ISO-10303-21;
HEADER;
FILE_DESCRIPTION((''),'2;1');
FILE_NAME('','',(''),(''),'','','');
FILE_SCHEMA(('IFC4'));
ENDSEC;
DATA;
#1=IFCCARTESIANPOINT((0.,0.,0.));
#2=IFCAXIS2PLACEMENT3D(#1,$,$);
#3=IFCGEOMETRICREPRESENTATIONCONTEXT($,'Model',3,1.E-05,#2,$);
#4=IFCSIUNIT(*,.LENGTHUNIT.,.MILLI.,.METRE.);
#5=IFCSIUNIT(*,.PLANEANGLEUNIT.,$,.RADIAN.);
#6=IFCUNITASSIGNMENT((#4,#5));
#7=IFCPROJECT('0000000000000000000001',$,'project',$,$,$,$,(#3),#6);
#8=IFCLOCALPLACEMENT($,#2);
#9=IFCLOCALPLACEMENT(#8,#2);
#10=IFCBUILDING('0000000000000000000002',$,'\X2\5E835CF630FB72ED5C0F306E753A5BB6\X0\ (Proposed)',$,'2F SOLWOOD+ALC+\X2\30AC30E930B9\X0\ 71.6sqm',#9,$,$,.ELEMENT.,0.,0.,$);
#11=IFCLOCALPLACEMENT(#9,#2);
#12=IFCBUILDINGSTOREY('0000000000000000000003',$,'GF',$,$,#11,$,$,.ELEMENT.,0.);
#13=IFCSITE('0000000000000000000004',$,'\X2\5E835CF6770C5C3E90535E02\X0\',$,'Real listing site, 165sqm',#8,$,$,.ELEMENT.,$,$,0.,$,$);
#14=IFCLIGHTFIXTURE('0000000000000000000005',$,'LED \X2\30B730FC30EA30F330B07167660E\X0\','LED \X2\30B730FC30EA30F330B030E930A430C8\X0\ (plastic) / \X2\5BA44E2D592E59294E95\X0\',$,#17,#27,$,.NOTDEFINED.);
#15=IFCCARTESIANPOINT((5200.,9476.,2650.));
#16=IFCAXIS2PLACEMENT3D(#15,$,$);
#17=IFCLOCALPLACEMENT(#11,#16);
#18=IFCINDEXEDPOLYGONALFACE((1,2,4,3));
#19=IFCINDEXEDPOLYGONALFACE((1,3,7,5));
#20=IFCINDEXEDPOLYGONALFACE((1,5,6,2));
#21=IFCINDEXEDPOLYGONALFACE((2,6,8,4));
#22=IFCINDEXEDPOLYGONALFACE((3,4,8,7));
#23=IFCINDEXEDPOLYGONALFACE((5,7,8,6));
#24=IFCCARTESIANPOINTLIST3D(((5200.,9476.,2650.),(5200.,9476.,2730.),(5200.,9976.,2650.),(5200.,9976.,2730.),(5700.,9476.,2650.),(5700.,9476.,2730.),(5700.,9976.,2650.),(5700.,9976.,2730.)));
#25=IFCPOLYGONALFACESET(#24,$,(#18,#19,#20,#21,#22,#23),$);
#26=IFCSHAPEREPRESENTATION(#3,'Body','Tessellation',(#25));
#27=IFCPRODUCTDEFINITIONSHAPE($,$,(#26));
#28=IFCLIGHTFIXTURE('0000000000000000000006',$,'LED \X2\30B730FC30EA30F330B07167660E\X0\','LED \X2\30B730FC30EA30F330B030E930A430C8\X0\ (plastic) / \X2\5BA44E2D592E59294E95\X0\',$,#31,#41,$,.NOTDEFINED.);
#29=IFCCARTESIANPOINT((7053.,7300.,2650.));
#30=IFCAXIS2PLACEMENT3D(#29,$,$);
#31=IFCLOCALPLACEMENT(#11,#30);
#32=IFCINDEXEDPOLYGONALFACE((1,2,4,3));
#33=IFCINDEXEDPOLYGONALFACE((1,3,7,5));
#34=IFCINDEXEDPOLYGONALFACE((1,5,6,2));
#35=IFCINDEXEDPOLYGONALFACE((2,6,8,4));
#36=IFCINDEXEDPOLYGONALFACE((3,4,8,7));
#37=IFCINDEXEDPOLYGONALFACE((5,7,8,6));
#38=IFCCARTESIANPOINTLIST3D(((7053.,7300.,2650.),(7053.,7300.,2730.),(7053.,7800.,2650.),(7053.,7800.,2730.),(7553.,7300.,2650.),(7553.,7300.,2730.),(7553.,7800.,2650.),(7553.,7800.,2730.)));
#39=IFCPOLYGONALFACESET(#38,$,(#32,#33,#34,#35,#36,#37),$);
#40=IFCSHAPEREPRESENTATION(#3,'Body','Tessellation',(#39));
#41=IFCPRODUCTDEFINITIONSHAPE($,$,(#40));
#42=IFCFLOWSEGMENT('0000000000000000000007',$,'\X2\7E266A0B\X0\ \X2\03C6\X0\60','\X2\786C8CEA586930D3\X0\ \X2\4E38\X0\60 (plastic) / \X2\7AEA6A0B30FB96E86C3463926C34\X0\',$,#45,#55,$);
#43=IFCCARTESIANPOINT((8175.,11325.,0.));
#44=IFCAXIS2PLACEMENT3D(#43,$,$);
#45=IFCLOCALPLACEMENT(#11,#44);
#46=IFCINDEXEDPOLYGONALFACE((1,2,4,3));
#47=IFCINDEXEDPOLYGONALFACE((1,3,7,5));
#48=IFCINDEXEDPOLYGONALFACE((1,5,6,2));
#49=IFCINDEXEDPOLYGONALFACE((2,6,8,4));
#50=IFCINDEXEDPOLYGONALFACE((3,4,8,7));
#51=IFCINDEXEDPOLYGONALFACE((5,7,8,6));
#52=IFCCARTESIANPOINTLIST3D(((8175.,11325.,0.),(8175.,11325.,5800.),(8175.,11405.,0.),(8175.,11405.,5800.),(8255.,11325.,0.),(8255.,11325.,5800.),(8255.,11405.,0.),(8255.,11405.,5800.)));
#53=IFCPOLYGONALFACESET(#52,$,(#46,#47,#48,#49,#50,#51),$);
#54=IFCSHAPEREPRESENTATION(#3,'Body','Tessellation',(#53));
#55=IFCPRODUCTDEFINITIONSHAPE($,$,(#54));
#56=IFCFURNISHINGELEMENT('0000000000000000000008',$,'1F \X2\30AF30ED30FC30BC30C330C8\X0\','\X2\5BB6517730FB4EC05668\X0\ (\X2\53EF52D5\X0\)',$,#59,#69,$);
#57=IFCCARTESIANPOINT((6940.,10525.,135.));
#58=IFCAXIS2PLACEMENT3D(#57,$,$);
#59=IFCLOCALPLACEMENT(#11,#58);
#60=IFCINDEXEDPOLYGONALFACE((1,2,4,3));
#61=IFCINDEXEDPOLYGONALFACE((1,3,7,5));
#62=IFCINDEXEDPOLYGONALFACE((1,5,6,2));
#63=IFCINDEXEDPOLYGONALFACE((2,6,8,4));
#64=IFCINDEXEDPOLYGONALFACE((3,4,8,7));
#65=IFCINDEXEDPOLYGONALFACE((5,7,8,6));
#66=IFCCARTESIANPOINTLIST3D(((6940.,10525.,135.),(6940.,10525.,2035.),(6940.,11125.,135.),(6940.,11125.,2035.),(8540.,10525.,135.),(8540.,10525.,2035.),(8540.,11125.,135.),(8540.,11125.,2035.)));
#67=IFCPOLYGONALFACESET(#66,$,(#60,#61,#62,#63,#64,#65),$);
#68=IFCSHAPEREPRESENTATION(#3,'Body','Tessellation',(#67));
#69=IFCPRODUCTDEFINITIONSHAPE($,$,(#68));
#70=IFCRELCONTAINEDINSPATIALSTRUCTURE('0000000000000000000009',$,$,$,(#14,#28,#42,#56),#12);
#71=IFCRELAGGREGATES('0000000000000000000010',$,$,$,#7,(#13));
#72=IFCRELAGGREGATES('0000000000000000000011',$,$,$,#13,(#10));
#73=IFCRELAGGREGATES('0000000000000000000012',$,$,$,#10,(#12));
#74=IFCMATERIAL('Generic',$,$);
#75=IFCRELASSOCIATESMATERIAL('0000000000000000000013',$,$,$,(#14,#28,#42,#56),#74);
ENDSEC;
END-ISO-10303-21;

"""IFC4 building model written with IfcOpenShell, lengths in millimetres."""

from ifc_helpers import new_model, si_unit, frame, frame_2d, origin, place, context, project, spatial, rectangle, extrude, material, element, save


model = new_model("IFC4")

# Units and contexts
model_context = context("Model", 3, precision=1e-05, world=origin())
ifc_project = project(units=[si_unit("LENGTHUNIT", "METRE", prefix="MILLI"), si_unit("PLANEANGLEUNIT", "RADIAN")], contexts=[model_context])

# Site, building, storey
site_placement = place(None, origin())
site = spatial("IfcSite", under=ifc_project, at=site_placement, Name="広島県尾道市", ObjectType="Real listing site, 165sqm", CompositionType="ELEMENT", RefElevation=0.0)
building_placement = place(site_placement, origin())
building = spatial("IfcBuilding", under=site, at=building_placement, Name="広島・狭小の町家 (Proposed)", ObjectType="2F SOLWOOD+ALC+ガラス 71.6sqm", CompositionType="ELEMENT", ElevationOfRefHeight=0.0, ElevationOfTerrain=0.0)
storey_placement = place(building_placement, origin())
storey = spatial("IfcBuildingStorey", under=building, at=storey_placement, Name="GF", CompositionType="ELEMENT", Elevation=0.0)

# Shared definitions
ifc_material_1 = material(Name="Generic")

# Light fixtures
light_fixture_1_placement = place(storey_placement, frame((5200.0, 9476.0, 2650.0)))
element("IfcLightFixture", 1, at=light_fixture_1_placement, inside=storey, material=ifc_material_1, Name="LED シーリング照明", Description="LED シーリングライト (plastic) / 室中央天井", PredefinedType="NOTDEFINED", context=model_context, shape_type="SweptSolid", body=[
    extrude(rectangle(XDim=500.0, YDim=500.0, at=frame_2d((250.0, 250.0))), frame((5200.0, 9476.0, 2650.0)), (0.0, 0.0, 1.0), 80.0),
])
light_fixture_2_placement = place(storey_placement, frame((7053.0, 7300.0, 2650.0)))
element("IfcLightFixture", 2, at=light_fixture_2_placement, inside=storey, material=ifc_material_1, Name="LED シーリング照明", Description="LED シーリングライト (plastic) / 室中央天井", PredefinedType="NOTDEFINED", context=model_context, shape_type="SweptSolid", body=[
    extrude(rectangle(XDim=500.0, YDim=500.0, at=frame_2d((250.0, 250.0))), frame((7053.0, 7300.0, 2650.0)), (0.0, 0.0, 1.0), 80.0),
])

# Flow segment
flow_segment_placement = place(storey_placement, frame((8175.0, 11325.0, 0.0)))
element("IfcFlowSegment", 3, at=flow_segment_placement, inside=storey, material=ifc_material_1, Name="縦樋 φ60", Description="硬質塩ビ 丸60 (plastic) / 竪樋・雨水排水", context=model_context, shape_type="SweptSolid", body=[
    extrude(rectangle(XDim=80.0, YDim=80.0, at=frame_2d((40.0, 40.0))), frame((8175.0, 11325.0, 0.0)), (0.0, 0.0, 1.0), 5800.0),
])

# Furnishing element
furnishing_placement = place(storey_placement, frame((6940.0, 10525.0, 135.0)))
element("IfcFurnishingElement", 4, at=furnishing_placement, inside=storey, material=ifc_material_1, Name="1F クローゼット", Description="家具・什器 (可動)", context=model_context, shape_type="SweptSolid", body=[
    extrude(rectangle(XDim=1600.0, YDim=600.0, at=frame_2d((800.0, 300.0))), frame((6940.0, 10525.0, 135.0)), (0.0, 0.0, 1.0), 1900.0),
])

save(model, "model.ifc")
